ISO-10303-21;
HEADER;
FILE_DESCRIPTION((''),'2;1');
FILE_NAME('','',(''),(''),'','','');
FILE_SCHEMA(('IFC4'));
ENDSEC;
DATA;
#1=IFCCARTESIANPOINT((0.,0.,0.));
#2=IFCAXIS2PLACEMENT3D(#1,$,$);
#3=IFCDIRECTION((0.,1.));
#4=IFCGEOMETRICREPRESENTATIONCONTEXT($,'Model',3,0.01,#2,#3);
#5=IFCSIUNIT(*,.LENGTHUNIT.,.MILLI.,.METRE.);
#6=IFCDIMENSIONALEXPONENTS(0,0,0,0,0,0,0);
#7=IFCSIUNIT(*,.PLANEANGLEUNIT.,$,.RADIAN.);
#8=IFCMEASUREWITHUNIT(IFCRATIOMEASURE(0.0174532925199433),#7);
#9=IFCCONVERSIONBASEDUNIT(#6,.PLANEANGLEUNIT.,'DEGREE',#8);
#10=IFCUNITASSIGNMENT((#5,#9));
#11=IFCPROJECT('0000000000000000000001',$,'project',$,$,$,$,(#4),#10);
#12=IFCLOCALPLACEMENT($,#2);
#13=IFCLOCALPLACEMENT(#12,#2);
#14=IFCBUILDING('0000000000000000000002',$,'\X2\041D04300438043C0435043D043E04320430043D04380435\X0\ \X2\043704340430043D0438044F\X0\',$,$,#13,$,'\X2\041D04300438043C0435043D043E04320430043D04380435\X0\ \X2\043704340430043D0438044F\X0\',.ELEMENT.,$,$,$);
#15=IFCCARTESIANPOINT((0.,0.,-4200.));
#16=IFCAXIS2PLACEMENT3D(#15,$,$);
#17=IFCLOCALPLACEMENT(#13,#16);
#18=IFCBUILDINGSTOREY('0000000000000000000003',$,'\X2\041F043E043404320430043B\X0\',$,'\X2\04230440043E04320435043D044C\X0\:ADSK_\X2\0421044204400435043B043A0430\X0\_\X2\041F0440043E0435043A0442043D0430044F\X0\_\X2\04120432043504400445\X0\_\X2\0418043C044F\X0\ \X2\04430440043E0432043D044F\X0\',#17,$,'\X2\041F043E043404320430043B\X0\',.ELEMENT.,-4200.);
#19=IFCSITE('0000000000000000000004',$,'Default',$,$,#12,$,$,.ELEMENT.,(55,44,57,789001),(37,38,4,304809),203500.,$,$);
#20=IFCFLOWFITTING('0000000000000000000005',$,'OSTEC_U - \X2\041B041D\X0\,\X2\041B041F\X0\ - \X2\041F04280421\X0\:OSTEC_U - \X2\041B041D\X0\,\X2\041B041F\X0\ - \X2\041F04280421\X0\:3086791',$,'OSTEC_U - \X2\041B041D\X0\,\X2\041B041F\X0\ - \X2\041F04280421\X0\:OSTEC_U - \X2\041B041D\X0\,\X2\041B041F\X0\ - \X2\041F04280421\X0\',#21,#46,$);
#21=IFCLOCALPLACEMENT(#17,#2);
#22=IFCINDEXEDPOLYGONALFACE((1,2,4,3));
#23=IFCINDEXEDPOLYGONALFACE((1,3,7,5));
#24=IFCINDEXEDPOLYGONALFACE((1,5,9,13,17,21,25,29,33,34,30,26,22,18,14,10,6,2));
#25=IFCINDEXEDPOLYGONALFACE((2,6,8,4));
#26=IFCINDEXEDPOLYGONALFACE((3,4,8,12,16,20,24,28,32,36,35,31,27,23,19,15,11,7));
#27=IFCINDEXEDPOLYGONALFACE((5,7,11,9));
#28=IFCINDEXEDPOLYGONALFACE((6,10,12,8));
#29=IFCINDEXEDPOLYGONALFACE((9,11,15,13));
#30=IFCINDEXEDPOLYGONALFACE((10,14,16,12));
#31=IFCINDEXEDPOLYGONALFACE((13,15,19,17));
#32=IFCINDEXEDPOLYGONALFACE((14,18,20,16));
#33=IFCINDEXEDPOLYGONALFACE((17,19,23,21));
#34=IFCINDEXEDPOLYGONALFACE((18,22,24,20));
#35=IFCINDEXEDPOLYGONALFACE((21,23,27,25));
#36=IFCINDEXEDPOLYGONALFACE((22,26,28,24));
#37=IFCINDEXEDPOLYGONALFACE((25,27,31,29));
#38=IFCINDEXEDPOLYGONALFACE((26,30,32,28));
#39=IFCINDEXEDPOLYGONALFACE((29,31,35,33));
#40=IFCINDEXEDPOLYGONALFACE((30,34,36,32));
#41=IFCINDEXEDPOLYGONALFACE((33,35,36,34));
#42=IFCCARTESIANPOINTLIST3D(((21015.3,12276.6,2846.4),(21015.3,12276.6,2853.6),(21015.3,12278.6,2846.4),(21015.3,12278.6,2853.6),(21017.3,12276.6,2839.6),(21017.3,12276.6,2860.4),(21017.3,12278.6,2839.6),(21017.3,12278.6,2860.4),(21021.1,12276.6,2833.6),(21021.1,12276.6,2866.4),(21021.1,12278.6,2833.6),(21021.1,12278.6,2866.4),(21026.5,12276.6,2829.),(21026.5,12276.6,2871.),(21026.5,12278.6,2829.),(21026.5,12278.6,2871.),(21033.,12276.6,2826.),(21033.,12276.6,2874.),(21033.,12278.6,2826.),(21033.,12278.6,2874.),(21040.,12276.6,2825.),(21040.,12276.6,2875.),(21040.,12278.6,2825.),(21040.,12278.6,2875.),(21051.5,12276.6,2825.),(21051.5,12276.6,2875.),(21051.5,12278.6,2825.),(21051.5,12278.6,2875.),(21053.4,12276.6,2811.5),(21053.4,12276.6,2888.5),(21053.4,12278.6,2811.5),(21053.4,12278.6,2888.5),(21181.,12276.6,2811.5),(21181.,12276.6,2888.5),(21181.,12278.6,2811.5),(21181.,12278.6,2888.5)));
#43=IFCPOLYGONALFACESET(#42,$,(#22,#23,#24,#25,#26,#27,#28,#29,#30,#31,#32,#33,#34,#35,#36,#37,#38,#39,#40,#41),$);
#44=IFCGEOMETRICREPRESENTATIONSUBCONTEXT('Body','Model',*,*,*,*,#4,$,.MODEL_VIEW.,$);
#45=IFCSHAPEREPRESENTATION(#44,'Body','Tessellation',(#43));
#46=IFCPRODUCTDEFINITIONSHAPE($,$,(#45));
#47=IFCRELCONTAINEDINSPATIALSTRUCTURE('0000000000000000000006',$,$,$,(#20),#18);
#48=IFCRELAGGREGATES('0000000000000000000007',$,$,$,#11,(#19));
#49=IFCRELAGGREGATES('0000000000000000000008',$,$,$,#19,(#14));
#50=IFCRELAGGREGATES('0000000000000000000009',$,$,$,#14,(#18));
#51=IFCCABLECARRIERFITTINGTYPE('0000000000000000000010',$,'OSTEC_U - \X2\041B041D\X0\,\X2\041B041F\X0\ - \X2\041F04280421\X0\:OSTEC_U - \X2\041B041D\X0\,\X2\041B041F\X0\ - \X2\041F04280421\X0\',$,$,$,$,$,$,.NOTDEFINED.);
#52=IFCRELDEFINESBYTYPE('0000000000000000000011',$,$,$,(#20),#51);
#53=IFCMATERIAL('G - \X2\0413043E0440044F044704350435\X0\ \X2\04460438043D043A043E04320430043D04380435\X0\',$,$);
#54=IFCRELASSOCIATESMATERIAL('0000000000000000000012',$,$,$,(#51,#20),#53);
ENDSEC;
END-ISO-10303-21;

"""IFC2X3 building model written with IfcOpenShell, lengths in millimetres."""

from ifc_helpers import new_model, entity, si_unit, converted_unit, direction, frame, frame_2d, origin, place, context, subcontext, project, spatial, polyline, circle_curve, parameter, trimmed, segment, composite_curve, outline, extrude, source, transform, mapped, material, type_object, type_shapes, element, save


model = new_model("IFC2X3")

# Units and contexts
model_context = context("Model", 3, precision=0.01, world=origin(), true_north=direction((0.0, 1.0)))
body_context = subcontext(model_context, "Body", "Model", "MODEL_VIEW")
ifc_project = project(units=[si_unit("LENGTHUNIT", "METRE", prefix="MILLI"), converted_unit("PLANEANGLEUNIT", "DEGREE", entity("IfcRatioMeasure", 0.0174532925199433), si_unit("PLANEANGLEUNIT", "RADIAN"), dimensions=[0, 0, 0, 0, 0, 0, 0])], contexts=[model_context])

# Site, building, storey
site_placement = place(None, origin())
site = spatial("IfcSite", under=ifc_project, at=site_placement, Name="Default", CompositionType="ELEMENT", RefLatitude=(55, 44, 57, 789001), RefLongitude=(37, 38, 4, 304809), RefElevation=203500.0)
building_placement = place(site_placement, origin())
building = spatial("IfcBuilding", under=site, at=building_placement, Name="Наименование здания", LongName="Наименование здания", CompositionType="ELEMENT")
storey_placement = place(building_placement, frame((0.0, 0.0, -4200.0)))
storey = spatial("IfcBuildingStorey", under=building, at=storey_placement, Name="Подвал", ObjectType="Уровень:ADSK_Стрелка_Проектная_Вверх_Имя уровня", LongName="Подвал", CompositionType="ELEMENT", Elevation=-4200.0)

# Flow fitting
ifc_material_1 = material(Name="G - Горячее цинкование")
cable_carrier_fitting_type_1 = type_object("IfcCableCarrierFittingType", Name="OSTEC_U - ЛН,ЛП - ПШС:OSTEC_U - ЛН,ЛП - ПШС", PredefinedType="NOTDEFINED", material=ifc_material_1)
shared_shape_1 = source(origin(), body_context, "Body", "SweptSolid", [
    extrude(outline(composite_curve([segment(trimmed(circle_curve(frame_2d((-41.5, 0.0), x_axis=(1.0, 0.0)), 25.0), [parameter(90.0)], [parameter(270.0)], True, "PARAMETER"), True, "CONTINUOUS"), segment(polyline([(-41.5, -25.0), (-30.0, -25.0)]), True, "CONTINUOUS"), segment(polyline([(-30.0, -25.0), (-28.1, -38.5)]), True, "CONTINUOUS"), segment(polyline([(-28.1, -38.5), (99.5, -38.5)]), True, "CONTINUOUS"), segment(polyline([(99.5, -38.5), (99.5, 38.5)]), True, "CONTINUOUS"), segment(polyline([(99.5, 38.5), (-28.1, 38.5)]), True, "CONTINUOUS"), segment(polyline([(-28.1, 38.5), (-30.0, 25.0)]), True, "CONTINUOUS"), segment(polyline([(-30.0, 25.0), (-41.5, 25.0)]), True, "CONTINUOUS")], self_intersect=False)), frame((41.5, 0.0, 0.0)), (0.0, 0.0, 1.0), 2.0),
])
type_shapes(cable_carrier_fitting_type_1, [shared_shape_1])
for number, where, z_axis, x_axis, name in (
    (1, (21040.0, 12278.6, 2850.0), (0.0, -1.0, 0.0), (1.0, 0.0, 0.000053), "OSTEC_U - ЛН,ЛП - ПШС:OSTEC_U - ЛН,ЛП - ПШС:3086791"),
):
    element("IfcFlowFitting", number, at=place(storey_placement, frame(where, z_axis=z_axis, x_axis=x_axis)), inside=storey, type_object=cable_carrier_fitting_type_1, material=ifc_material_1, Name=name, ObjectType="OSTEC_U - ЛН,ЛП - ПШС:OSTEC_U - ЛН,ЛП - ПШС", context=body_context, shape_type="MappedRepresentation", body=[
        mapped(shared_shape_1, transform((0.0, 0.0, 0.0), scale=1.0)),
    ])

save(model, "model.ifc")
